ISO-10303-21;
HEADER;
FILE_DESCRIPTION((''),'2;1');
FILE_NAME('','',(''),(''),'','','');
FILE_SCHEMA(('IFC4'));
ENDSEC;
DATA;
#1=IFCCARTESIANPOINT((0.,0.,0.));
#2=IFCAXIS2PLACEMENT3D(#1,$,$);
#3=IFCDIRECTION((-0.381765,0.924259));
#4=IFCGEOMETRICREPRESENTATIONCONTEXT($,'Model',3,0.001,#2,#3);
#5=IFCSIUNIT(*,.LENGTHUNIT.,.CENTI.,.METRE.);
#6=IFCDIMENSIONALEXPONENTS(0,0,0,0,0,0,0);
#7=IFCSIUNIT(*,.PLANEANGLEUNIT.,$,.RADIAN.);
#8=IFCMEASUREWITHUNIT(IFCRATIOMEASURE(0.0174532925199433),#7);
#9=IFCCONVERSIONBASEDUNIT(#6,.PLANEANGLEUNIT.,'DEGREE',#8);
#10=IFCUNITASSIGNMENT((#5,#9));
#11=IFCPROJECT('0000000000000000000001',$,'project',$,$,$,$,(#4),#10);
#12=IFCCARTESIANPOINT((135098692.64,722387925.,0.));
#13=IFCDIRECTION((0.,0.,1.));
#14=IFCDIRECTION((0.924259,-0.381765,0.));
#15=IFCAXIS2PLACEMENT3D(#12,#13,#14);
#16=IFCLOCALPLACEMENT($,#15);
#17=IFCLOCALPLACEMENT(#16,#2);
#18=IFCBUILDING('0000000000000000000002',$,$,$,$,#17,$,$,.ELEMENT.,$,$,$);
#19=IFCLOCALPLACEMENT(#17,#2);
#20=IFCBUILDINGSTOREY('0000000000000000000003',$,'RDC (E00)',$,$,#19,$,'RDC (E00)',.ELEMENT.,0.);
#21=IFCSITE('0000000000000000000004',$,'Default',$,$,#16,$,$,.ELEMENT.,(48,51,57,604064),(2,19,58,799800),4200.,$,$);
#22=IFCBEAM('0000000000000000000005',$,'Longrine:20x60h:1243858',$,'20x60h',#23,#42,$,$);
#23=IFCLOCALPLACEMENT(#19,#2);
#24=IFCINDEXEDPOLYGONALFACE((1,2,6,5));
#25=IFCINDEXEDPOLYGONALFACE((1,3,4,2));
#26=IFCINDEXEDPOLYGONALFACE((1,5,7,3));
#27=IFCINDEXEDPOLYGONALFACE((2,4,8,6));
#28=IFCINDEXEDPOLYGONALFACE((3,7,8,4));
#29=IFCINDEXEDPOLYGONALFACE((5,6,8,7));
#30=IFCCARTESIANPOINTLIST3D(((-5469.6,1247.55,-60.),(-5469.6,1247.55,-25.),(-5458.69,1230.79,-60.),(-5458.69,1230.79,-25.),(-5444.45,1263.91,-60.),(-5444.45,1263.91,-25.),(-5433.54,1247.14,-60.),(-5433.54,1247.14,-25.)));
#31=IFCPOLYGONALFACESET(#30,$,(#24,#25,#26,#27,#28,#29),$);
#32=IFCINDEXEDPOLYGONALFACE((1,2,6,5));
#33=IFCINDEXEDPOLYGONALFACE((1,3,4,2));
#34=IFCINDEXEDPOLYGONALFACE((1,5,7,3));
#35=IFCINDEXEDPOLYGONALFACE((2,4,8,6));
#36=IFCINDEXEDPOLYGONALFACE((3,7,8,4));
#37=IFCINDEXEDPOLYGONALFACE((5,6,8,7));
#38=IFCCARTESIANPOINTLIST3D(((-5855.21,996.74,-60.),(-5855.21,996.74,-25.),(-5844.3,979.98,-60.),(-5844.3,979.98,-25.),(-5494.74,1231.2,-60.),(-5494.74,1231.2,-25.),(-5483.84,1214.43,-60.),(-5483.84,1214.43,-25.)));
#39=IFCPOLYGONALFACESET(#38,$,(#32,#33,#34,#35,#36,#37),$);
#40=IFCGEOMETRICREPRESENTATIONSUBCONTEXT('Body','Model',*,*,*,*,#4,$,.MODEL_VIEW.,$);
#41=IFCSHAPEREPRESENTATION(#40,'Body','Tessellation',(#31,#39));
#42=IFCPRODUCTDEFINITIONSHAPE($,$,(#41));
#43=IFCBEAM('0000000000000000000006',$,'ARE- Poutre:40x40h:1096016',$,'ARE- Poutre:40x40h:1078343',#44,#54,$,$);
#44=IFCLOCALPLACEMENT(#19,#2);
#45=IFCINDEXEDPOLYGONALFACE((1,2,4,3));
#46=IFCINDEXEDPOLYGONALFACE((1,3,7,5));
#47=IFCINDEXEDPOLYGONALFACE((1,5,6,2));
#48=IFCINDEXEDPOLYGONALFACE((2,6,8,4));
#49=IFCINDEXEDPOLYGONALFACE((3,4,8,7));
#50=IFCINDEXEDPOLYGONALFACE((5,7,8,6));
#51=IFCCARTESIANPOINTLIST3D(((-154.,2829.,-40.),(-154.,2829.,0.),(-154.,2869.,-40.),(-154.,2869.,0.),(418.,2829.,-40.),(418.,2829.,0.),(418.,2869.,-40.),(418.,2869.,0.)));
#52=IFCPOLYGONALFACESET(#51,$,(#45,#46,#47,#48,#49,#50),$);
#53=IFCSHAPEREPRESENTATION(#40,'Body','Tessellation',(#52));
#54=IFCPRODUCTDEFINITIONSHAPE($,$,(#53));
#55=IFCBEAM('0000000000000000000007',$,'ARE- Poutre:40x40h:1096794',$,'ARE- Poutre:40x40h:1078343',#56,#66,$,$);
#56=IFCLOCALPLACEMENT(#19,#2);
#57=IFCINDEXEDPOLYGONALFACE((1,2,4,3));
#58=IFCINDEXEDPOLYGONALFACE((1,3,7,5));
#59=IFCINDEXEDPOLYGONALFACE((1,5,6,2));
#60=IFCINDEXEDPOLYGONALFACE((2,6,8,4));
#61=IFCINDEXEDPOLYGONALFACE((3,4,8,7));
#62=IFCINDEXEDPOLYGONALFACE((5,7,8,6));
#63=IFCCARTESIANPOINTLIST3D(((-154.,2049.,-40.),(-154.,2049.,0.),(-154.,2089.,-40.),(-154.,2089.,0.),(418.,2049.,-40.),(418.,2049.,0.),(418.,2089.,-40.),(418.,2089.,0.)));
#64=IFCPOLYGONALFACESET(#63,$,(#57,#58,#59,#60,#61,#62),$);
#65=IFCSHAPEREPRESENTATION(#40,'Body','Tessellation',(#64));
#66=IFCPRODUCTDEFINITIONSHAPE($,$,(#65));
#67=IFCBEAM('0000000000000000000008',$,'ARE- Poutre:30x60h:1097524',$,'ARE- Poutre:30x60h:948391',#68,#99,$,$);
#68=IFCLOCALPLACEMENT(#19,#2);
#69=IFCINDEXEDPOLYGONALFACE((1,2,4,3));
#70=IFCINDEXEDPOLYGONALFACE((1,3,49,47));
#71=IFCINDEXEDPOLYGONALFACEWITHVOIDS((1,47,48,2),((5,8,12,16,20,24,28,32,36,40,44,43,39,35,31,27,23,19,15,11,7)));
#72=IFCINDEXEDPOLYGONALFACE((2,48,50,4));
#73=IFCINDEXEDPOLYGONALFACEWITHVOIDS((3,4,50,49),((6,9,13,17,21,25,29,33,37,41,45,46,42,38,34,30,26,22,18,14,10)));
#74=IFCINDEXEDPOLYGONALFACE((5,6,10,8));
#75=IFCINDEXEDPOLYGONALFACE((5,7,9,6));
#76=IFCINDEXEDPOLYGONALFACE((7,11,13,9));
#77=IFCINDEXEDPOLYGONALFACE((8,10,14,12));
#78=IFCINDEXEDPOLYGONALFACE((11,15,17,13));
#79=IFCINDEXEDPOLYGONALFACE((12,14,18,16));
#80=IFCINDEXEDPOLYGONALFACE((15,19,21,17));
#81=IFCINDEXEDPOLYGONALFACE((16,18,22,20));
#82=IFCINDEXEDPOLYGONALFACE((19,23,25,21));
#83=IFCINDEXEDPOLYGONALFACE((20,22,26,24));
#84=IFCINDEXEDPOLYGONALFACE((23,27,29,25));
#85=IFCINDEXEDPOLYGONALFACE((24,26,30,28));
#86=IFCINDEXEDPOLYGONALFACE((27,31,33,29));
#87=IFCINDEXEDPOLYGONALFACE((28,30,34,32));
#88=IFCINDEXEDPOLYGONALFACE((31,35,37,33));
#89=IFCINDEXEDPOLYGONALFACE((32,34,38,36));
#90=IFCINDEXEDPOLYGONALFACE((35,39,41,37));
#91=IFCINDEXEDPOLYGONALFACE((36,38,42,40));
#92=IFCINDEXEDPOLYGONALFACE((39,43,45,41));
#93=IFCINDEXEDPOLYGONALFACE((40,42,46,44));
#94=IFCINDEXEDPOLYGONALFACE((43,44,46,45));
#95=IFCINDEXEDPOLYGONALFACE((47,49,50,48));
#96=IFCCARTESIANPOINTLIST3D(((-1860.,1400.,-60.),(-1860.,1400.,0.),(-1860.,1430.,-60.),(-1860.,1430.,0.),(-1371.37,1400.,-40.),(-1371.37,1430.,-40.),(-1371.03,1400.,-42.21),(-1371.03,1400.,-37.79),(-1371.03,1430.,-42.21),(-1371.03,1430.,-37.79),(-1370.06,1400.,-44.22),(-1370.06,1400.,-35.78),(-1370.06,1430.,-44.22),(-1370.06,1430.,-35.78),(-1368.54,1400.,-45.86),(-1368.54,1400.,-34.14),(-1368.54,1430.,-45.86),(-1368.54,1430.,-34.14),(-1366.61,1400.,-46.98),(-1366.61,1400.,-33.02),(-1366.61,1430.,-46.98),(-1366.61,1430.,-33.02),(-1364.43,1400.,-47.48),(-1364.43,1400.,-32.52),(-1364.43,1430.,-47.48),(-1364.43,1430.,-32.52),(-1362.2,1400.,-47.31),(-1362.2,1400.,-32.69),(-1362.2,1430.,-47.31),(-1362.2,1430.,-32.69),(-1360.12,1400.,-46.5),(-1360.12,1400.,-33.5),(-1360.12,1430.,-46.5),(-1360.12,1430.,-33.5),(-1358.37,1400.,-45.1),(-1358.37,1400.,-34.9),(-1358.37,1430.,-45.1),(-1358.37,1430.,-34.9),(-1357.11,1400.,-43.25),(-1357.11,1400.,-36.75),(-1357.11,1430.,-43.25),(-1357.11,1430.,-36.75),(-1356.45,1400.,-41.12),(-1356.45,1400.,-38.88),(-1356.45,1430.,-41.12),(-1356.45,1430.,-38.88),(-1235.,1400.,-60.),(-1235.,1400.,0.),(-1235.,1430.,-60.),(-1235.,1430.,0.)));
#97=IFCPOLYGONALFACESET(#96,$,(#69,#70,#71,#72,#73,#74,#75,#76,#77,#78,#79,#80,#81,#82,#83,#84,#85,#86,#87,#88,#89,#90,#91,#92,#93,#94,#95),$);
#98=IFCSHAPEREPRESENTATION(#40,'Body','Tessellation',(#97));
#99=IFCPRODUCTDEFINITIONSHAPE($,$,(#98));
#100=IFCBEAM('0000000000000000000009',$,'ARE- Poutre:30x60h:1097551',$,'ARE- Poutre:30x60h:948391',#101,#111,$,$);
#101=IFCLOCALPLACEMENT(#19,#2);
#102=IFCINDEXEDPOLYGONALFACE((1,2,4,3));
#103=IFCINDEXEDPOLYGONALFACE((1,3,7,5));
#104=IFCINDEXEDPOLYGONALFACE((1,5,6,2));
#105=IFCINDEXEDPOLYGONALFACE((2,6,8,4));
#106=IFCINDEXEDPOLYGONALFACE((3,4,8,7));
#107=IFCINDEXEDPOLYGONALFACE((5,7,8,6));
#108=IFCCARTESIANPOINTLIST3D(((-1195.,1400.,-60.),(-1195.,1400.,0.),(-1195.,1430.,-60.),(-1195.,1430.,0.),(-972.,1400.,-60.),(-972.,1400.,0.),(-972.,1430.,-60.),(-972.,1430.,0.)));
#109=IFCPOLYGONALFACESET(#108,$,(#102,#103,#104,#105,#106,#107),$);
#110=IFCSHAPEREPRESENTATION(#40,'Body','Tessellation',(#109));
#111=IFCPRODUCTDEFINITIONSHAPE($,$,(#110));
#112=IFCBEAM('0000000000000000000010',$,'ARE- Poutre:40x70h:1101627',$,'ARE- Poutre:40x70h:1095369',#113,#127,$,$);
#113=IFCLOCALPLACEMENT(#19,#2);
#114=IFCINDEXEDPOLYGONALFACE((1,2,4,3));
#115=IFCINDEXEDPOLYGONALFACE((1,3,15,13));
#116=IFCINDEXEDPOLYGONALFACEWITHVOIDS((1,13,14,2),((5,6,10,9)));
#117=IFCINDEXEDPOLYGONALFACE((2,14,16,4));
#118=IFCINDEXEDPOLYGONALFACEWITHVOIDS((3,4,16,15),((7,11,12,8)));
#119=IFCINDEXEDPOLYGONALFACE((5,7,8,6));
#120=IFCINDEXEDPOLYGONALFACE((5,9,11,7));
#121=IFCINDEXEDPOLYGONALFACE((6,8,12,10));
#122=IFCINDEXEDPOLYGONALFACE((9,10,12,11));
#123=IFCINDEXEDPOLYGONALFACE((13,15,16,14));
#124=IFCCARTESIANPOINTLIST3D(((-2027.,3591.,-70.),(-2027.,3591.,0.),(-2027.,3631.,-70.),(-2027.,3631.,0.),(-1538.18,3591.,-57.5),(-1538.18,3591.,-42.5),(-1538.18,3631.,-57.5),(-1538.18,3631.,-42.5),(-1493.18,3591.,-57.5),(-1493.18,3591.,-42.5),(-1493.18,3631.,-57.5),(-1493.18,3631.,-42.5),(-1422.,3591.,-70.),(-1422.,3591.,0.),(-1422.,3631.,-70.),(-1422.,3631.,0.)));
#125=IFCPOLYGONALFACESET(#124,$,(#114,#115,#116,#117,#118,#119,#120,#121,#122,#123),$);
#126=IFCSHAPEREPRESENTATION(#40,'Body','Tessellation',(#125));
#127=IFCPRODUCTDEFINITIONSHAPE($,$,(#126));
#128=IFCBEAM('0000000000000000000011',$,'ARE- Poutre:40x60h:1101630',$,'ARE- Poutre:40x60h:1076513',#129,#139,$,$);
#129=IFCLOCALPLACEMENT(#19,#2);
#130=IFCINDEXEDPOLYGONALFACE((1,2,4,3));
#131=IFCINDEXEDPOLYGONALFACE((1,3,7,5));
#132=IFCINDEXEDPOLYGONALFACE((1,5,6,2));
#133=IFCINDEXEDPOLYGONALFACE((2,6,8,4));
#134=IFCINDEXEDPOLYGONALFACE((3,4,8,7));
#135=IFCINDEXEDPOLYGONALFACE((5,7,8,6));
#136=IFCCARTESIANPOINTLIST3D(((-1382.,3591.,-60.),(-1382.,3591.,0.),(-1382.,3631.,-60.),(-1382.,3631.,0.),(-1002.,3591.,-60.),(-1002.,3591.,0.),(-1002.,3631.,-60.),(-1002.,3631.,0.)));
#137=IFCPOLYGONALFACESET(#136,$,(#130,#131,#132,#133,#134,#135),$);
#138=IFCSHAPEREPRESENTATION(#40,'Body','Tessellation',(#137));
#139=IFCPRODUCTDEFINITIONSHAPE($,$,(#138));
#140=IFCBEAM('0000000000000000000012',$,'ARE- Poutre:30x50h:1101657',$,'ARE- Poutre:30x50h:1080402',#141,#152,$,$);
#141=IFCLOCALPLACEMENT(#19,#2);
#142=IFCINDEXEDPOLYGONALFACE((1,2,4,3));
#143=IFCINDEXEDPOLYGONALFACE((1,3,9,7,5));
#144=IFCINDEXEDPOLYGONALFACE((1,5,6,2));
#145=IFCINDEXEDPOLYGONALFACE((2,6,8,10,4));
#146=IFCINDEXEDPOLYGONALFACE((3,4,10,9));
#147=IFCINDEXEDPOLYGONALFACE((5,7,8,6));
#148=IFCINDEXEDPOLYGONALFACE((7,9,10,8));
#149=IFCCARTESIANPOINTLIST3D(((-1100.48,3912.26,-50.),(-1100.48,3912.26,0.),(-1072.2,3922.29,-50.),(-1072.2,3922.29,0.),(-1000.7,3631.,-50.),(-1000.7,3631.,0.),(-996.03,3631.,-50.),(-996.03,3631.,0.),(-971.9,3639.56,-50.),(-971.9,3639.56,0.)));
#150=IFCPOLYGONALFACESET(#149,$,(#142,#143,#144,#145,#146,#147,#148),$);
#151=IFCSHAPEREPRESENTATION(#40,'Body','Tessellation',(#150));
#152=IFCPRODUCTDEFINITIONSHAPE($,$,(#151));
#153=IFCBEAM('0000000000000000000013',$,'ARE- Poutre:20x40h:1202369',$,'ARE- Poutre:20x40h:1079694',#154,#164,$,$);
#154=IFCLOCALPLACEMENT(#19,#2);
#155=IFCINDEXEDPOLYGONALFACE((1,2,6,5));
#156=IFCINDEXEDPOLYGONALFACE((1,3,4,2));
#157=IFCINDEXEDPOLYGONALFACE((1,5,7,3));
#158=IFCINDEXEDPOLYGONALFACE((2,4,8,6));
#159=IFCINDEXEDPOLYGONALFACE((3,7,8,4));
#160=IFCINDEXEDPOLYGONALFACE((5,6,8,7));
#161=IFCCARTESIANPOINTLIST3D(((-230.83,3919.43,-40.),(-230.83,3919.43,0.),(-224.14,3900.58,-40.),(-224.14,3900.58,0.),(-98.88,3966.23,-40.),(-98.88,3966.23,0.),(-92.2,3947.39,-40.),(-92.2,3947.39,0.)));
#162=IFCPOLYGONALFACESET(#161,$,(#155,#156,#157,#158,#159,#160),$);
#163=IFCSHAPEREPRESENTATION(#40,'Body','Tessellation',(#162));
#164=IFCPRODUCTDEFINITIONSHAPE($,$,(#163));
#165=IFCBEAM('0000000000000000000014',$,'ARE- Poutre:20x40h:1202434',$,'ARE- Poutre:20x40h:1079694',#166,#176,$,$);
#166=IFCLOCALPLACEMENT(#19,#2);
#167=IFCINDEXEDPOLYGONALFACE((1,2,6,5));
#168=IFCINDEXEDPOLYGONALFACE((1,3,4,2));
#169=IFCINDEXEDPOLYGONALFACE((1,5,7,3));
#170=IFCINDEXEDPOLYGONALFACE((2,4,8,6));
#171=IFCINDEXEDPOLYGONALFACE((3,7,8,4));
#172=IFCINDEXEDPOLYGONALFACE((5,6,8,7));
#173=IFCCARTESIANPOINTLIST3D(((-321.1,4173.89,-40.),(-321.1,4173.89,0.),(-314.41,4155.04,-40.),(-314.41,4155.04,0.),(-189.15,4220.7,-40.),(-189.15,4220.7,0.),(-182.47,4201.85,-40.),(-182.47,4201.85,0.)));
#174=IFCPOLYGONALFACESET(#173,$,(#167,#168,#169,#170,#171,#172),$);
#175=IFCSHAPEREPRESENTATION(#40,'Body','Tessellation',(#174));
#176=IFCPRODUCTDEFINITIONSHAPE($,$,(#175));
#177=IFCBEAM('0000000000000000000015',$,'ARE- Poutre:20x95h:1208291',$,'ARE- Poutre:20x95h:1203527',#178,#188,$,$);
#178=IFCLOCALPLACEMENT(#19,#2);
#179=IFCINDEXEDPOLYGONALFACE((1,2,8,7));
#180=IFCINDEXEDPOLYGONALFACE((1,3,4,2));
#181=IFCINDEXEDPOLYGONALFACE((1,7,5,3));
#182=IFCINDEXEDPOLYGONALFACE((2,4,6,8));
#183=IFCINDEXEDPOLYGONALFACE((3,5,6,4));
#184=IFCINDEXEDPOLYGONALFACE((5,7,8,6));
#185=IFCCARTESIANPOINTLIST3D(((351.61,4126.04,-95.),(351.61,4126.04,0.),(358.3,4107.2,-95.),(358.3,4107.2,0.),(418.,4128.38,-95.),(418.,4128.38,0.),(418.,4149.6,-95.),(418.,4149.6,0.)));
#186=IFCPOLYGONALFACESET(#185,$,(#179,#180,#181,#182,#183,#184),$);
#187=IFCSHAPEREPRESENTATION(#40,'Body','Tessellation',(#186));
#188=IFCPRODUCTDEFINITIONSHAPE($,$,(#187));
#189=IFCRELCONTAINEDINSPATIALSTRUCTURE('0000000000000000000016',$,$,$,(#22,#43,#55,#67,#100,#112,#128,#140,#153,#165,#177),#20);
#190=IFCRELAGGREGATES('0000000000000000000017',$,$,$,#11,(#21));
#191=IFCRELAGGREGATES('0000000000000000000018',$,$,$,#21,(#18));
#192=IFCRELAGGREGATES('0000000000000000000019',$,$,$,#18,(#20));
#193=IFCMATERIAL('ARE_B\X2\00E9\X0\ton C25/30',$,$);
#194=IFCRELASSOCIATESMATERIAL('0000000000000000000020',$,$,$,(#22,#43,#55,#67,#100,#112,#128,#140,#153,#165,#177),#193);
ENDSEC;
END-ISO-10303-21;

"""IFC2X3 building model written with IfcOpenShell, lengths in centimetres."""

from ifc_helpers import new_model, entity, si_unit, converted_unit, direction, frame, frame_2d, origin, origin_2d_with_axis, place, context, subcontext, project, spatial, rectangle, circle, extrude, boolean, clip, halfspace, source, transform, mapped, material, element, save


model = new_model("IFC2X3")

# Units and contexts
model_context = context("Model", 3, precision=0.001, world=origin(), true_north=direction((-0.381765, 0.924259)))
body_context = subcontext(model_context, "Body", "Model", "MODEL_VIEW")
ifc_project = project(units=[si_unit("LENGTHUNIT", "METRE", prefix="CENTI"), converted_unit("PLANEANGLEUNIT", "DEGREE", entity("IfcRatioMeasure", 0.0174532925199433), si_unit("PLANEANGLEUNIT", "RADIAN"), dimensions=[0, 0, 0, 0, 0, 0, 0])], contexts=[model_context])

# Site, building, storey
site_placement = place(None, frame((135098692.64, 722387925.0, 0.0), z_axis=(0.0, 0.0, 1.0), x_axis=(0.924259, -0.381765, 0.0)))
site = spatial("IfcSite", under=ifc_project, at=site_placement, Name="Default", CompositionType="ELEMENT", RefLatitude=(48, 51, 57, 604064), RefLongitude=(2, 19, 58, 799800), RefElevation=4200.0)
building_placement = place(site_placement, origin())
building = spatial("IfcBuilding", under=site, at=building_placement, CompositionType="ELEMENT")
storey_placement = place(building_placement, origin())
storey = spatial("IfcBuildingStorey", under=building, at=storey_placement, Name="RDC (E00)", LongName="RDC (E00)", CompositionType="ELEMENT", Elevation=0.0)

# Beams
ifc_material = material(Name="ARE_Béton C25/30")
shared_shape_1 = source(origin(), body_context, "Body", "SweptSolid", [
    extrude(rectangle(XDim=30.0, YDim=20.0, at=frame_2d((0.0, 0.0), x_axis=(1.0, 0.0))), frame((-5451.57, 1247.35, -60.0), z_axis=(0.0, 0.0, 1.0), x_axis=(-0.838282, -0.545236, 0.0)), (0.0, 0.0, 1.0), 35.0),
    extrude(rectangle(XDim=430.0, YDim=20.0, at=frame_2d((0.0, 0.0), x_axis=(1.0, 0.0))), frame((-5669.52, 1105.59, -60.0), z_axis=(0.0, 0.0, 1.0), x_axis=(0.838282, 0.545236, 0.0)), (0.0, 0.0, 1.0), 35.0),
])
beam_1_placement = place(storey_placement, origin())
element("IfcBeam", 1, at=beam_1_placement, inside=storey, material=ifc_material, Name="Longrine:20x60h:1243858", ObjectType="20x60h", context=body_context, shape_type="MappedRepresentation", body=[
    mapped(shared_shape_1, transform((0.0, 0.0, 0.0), scale=1.0)),
])
beam_2_placement = place(storey_placement, frame((-154.0, 2849.0, 0.0)))
element("IfcBeam", 2, at=beam_2_placement, inside=storey, material=ifc_material, Name="ARE- Poutre:40x40h:1096016", ObjectType="ARE- Poutre:40x40h:1078343", context=body_context, shape_type="SweptSolid", body=[
    extrude(rectangle(XDim=40.0, YDim=40.0, at=frame_2d((0.0, 0.0), x_axis=(1.0, 0.0))), frame((0.0, 0.0, -20.0), z_axis=(1.0, 0.0, 0.0), x_axis=(0.0, 0.0, -1.0)), (0.0, 0.0, 1.0), 572.0),
])
beam_3_placement = place(storey_placement, frame((-154.0, 2069.0, 0.0)))
element("IfcBeam", 3, at=beam_3_placement, inside=storey, material=ifc_material, Name="ARE- Poutre:40x40h:1096794", ObjectType="ARE- Poutre:40x40h:1078343", context=body_context, shape_type="SweptSolid", body=[
    extrude(rectangle(XDim=40.0, YDim=40.0, at=frame_2d((0.0, 0.0), x_axis=(1.0, 0.0))), frame((0.0, 0.0, -20.0), z_axis=(1.0, 0.0, 0.0), x_axis=(0.0, 0.0, -1.0)), (0.0, 0.0, 1.0), 572.0),
])
beam_4_placement = place(storey_placement, frame((-1870.0, 1415.0, 0.0)))
element("IfcBeam", 4, at=beam_4_placement, inside=storey, material=ifc_material, Name="ARE- Poutre:30x60h:1097524", ObjectType="ARE- Poutre:30x60h:948391", context=body_context, shape_type="CSG", body=[
    boolean("DIFFERENCE", extrude(rectangle(XDim=60.0, YDim=30.0, at=frame_2d((0.0, 0.0), x_axis=(0.0, 1.0))), frame((10.0, 0.0, -30.0), z_axis=(1.0, 0.0, 0.0), x_axis=(0.0, 1.0, 0.0)), (0.0, 0.0, 1.0), 625.0), extrude(circle(Radius=7.5, at=frame_2d((0.0, 0.0), x_axis=(1.0, 0.0))), frame((506.13, 15.0, -40.0), z_axis=(0.0, -1.0, 0.0), x_axis=(-1.0, 0.0, 0.0)), (0.0, 0.0, 1.0), 30.0)),
])
beam_5_placement = place(storey_placement, frame((-1195.0, 1415.0, 0.0)))
element("IfcBeam", 5, at=beam_5_placement, inside=storey, material=ifc_material, Name="ARE- Poutre:30x60h:1097551", ObjectType="ARE- Poutre:30x60h:948391", context=body_context, shape_type="SweptSolid", body=[
    extrude(rectangle(XDim=60.0, YDim=30.0, at=frame_2d((0.0, 0.0), x_axis=(1.0, 0.0))), frame((0.0, 0.0, -30.0), z_axis=(1.0, 0.0, 0.0), x_axis=(0.0, 0.0, -1.0)), (0.0, 0.0, 1.0), 223.0),
])
beam_6_placement = place(storey_placement, frame((-2027.0, 3611.0, 0.0)))
element("IfcBeam", 6, at=beam_6_placement, inside=storey, material=ifc_material, Name="ARE- Poutre:40x70h:1101627", ObjectType="ARE- Poutre:40x70h:1095369", context=body_context, shape_type="CSG", body=[
    boolean("DIFFERENCE", extrude(rectangle(XDim=70.0, YDim=40.0, at=frame_2d((0.0, 0.0), x_axis=(0.0, 1.0))), frame((0.0, 0.0, -35.0), z_axis=(1.0, 0.0, 0.0), x_axis=(0.0, 1.0, 0.0)), (0.0, 0.0, 1.0), 605.0), extrude(rectangle(XDim=15.0, YDim=45.0, at=frame_2d((0.0, 0.0), x_axis=(0.0, 1.0))), frame((511.32, 20.0, -50.0), z_axis=(0.0, -1.0, 0.0), x_axis=(-1.0, 0.0, 0.0)), (0.0, 0.0, 1.0), 40.0)),
])
beam_7_placement = place(storey_placement, frame((-1382.0, 3611.0, 0.0)))
element("IfcBeam", 7, at=beam_7_placement, inside=storey, material=ifc_material, Name="ARE- Poutre:40x60h:1101630", ObjectType="ARE- Poutre:40x60h:1076513", context=body_context, shape_type="SweptSolid", body=[
    extrude(rectangle(XDim=60.0, YDim=40.0, at=frame_2d((0.0, 0.0), x_axis=(1.0, 0.0))), frame((0.0, 0.0, -30.0), z_axis=(1.0, 0.0, 0.0), x_axis=(0.0, 0.0, -1.0)), (0.0, 0.0, 1.0), 380.0),
])
beam_8_placement = place(storey_placement, frame((-1086.34, 3917.28, 0.0), z_axis=(0.0, 0.0, 1.0), x_axis=(0.334331, -0.942456, 0.0)))
element("IfcBeam", 8, at=beam_8_placement, inside=storey, material=ifc_material, Name="ARE- Poutre:30x50h:1101657", ObjectType="ARE- Poutre:30x50h:1080402", context=body_context, shape_type="Clipping", body=[
    clip(extrude(rectangle(XDim=50.0, YDim=30.0, at=origin_2d_with_axis()), frame((0.0, 0.0, -25.0), z_axis=(1.0, 0.0, 0.0), x_axis=(0.0, 0.0, -1.0)), (0.0, 0.0, 1.0), 300.0), halfspace(frame((308.03, 12.05, 0.0), z_axis=(0.942456, -0.334331, 0.0), x_axis=(0.0, 0.0, -1.0)), False)),
])
beam_9_placement = place(storey_placement, frame((-95.54, 3956.81, 0.0), z_axis=(0.0, 0.0, 1.0), x_axis=(-0.942456, -0.334331, 0.0)))
element("IfcBeam", 9, at=beam_9_placement, inside=storey, material=ifc_material, Name="ARE- Poutre:20x40h:1202369", ObjectType="ARE- Poutre:20x40h:1079694", context=body_context, shape_type="SweptSolid", body=[
    extrude(rectangle(XDim=40.0, YDim=20.0, at=frame_2d((0.0, 0.0), x_axis=(1.0, 0.0))), frame((0.0, 0.0, -20.0), z_axis=(1.0, 0.0, 0.0), x_axis=(0.0, 0.0, -1.0)), (0.0, 0.0, 1.0), 140.0),
])
beam_10_placement = place(storey_placement, frame((-176.39, 4214.62, 0.0), z_axis=(0.0, 0.0, 1.0), x_axis=(-0.942456, -0.334331, 0.0)))
element("IfcBeam", 10, at=beam_10_placement, inside=storey, material=ifc_material, Name="ARE- Poutre:20x40h:1202434", ObjectType="ARE- Poutre:20x40h:1079694", context=body_context, shape_type="SweptSolid", body=[
    extrude(rectangle(XDim=40.0, YDim=20.0, at=frame_2d((0.0, 0.0), x_axis=(1.0, 0.0))), frame((10.0, 0.0, -20.0), z_axis=(1.0, 0.0, 0.0), x_axis=(0.0, 0.0, -1.0)), (0.0, 0.0, 1.0), 140.0),
])
beam_11_placement = place(storey_placement, frame((345.53, 4113.28, 0.0), z_axis=(0.0, 0.0, 1.0), x_axis=(0.942456, 0.334331, 0.0)))
element("IfcBeam", 11, at=beam_11_placement, inside=storey, material=ifc_material, Name="ARE- Poutre:20x95h:1208291", ObjectType="ARE- Poutre:20x95h:1203527", context=body_context, shape_type="Clipping", body=[
    clip(extrude(rectangle(XDim=95.0, YDim=20.0, at=frame_2d((0.0, 0.0), x_axis=(1.0, 0.0))), frame((10.0, 0.0, -47.5), z_axis=(1.0, 0.0, 0.0), x_axis=(0.0, 0.0, -1.0)), (0.0, 0.0, 1.0), 70.44), halfspace(frame((80.44, 10.0, 0.0), z_axis=(0.942456, -0.334331, 0.0), x_axis=(0.0, 0.0, -1.0)), False)),
])

save(model, "model.ifc")
